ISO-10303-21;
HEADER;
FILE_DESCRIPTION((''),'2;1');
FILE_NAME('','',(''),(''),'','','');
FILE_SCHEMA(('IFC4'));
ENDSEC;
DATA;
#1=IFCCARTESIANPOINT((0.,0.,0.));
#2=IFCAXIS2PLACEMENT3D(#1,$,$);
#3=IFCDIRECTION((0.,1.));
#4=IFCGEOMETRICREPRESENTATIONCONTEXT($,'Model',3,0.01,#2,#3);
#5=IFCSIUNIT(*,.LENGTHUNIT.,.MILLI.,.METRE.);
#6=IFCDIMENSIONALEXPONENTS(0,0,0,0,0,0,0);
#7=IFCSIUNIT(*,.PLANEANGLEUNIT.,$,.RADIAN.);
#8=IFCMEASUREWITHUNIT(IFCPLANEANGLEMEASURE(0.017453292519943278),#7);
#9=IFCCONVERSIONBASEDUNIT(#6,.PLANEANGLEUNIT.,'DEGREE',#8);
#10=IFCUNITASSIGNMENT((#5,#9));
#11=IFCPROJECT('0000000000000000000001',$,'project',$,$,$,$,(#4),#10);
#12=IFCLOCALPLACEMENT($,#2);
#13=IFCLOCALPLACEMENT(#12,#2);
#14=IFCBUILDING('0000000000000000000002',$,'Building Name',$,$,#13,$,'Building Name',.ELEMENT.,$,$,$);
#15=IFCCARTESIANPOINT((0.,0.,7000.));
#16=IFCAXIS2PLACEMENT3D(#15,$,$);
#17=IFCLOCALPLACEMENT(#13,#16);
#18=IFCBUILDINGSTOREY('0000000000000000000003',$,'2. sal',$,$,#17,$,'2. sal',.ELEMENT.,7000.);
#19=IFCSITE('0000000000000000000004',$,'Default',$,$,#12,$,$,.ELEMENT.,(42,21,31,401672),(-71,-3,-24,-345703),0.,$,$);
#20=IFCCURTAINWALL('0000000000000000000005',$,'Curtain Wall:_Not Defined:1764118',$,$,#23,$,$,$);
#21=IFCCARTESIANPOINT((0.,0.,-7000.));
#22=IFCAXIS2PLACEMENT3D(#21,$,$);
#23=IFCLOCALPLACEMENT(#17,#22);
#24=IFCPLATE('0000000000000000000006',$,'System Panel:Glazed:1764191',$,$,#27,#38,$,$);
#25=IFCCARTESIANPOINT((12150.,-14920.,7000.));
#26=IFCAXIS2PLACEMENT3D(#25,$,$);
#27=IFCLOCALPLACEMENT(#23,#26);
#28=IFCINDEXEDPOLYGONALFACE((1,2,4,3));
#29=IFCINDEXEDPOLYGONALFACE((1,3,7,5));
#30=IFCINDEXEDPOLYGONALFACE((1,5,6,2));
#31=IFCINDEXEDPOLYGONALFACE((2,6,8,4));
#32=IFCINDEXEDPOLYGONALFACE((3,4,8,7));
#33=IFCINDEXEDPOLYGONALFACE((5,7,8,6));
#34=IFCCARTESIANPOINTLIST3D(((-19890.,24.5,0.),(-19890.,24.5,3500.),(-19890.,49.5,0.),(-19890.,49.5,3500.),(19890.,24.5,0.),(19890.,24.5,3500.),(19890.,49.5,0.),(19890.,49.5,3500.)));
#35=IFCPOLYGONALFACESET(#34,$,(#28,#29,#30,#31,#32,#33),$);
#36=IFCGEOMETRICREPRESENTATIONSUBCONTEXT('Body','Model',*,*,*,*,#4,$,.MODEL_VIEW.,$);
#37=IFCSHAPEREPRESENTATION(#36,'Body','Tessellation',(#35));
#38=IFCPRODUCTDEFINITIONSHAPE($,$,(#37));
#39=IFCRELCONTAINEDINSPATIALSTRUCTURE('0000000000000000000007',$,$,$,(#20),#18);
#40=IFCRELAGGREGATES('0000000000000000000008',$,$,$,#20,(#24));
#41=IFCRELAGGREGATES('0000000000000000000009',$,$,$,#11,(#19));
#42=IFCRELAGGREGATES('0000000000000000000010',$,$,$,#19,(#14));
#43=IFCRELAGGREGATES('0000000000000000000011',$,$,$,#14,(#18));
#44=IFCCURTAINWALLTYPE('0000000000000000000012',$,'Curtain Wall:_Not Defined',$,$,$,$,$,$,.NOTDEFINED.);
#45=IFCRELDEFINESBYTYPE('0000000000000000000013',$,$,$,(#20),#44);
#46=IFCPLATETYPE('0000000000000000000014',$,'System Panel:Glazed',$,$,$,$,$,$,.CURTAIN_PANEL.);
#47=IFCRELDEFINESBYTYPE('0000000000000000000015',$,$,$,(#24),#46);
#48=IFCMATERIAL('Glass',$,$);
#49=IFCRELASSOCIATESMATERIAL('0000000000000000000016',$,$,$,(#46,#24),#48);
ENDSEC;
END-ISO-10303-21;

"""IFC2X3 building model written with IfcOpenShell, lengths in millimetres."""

from ifc_helpers import new_model, entity, si_unit, converted_unit, direction, frame, origin, origin_2d_with_axis, place, context, subcontext, project, spatial, rectangle, extrude, source, transform, mapped, material, type_object, type_shapes, element, aggregate, save


model = new_model("IFC2X3")

# Units and contexts
model_context = context("Model", 3, precision=0.01, world=origin(), true_north=direction((0.0, 1.0)))
body_context = subcontext(model_context, "Body", "Model", "MODEL_VIEW")
ifc_project = project(units=[si_unit("LENGTHUNIT", "METRE", prefix="MILLI"), converted_unit("PLANEANGLEUNIT", "DEGREE", entity("IfcPlaneAngleMeasure", 0.017453292519943278), si_unit("PLANEANGLEUNIT", "RADIAN"), dimensions=[0, 0, 0, 0, 0, 0, 0])], contexts=[model_context])

# Site, building, storey
site_placement = place(None, origin())
site = spatial("IfcSite", under=ifc_project, at=site_placement, Name="Default", CompositionType="ELEMENT", RefLatitude=(42, 21, 31, 401672), RefLongitude=(-71, -3, -24, -345703), RefElevation=0.0)
building_placement = place(site_placement, origin())
building = spatial("IfcBuilding", under=site, at=building_placement, Name="Building Name", LongName="Building Name", CompositionType="ELEMENT")
storey_placement = place(building_placement, frame((0.0, 0.0, 7000.0)))
storey = spatial("IfcBuildingStorey", under=building, at=storey_placement, Name="2. sal", LongName="2. sal", CompositionType="ELEMENT", Elevation=7000.0)

# Curtain wall, plate
curtain_wall_type = type_object("IfcCurtainWallType", Name="Curtain Wall:_Not Defined", PredefinedType="NOTDEFINED")
curtain_wall_placement = place(storey_placement, frame((0.0, 0.0, -7000.0)))
curtain_wall = element("IfcCurtainWall", 1, at=curtain_wall_placement, inside=storey, type_object=curtain_wall_type, Name="Curtain Wall:_Not Defined:1764118")
ifc_material_1 = material(Name="Glass")
plate_type = type_object("IfcPlateType", Name="System Panel:Glazed", PredefinedType="CURTAIN_PANEL", material=ifc_material_1)
shared_shape = source(origin(), body_context, "Body", "SweptSolid", [
    extrude(rectangle(XDim=25.0, YDim=39780.0, at=origin_2d_with_axis()), frame((0.0, 37.0, 0.0), z_axis=(0.0, 0.0, 1.0), x_axis=(0.0, 1.0, 0.0)), (0.0, 0.0, 1.0), 3500.0),
])
type_shapes(plate_type, [shared_shape])
plate_placement = place(curtain_wall_placement, frame((12150.0, -14920.0, 7000.0)))
plate = element("IfcPlate", 2, at=plate_placement, type_object=plate_type, material=ifc_material_1, Name="System Panel:Glazed:1764191", context=body_context, shape_type="MappedRepresentation", body=[
    mapped(shared_shape, transform((0.0, 0.0, 0.0), scale=1.0)),
])
aggregate(curtain_wall, [plate])

save(model, "model.ifc")
